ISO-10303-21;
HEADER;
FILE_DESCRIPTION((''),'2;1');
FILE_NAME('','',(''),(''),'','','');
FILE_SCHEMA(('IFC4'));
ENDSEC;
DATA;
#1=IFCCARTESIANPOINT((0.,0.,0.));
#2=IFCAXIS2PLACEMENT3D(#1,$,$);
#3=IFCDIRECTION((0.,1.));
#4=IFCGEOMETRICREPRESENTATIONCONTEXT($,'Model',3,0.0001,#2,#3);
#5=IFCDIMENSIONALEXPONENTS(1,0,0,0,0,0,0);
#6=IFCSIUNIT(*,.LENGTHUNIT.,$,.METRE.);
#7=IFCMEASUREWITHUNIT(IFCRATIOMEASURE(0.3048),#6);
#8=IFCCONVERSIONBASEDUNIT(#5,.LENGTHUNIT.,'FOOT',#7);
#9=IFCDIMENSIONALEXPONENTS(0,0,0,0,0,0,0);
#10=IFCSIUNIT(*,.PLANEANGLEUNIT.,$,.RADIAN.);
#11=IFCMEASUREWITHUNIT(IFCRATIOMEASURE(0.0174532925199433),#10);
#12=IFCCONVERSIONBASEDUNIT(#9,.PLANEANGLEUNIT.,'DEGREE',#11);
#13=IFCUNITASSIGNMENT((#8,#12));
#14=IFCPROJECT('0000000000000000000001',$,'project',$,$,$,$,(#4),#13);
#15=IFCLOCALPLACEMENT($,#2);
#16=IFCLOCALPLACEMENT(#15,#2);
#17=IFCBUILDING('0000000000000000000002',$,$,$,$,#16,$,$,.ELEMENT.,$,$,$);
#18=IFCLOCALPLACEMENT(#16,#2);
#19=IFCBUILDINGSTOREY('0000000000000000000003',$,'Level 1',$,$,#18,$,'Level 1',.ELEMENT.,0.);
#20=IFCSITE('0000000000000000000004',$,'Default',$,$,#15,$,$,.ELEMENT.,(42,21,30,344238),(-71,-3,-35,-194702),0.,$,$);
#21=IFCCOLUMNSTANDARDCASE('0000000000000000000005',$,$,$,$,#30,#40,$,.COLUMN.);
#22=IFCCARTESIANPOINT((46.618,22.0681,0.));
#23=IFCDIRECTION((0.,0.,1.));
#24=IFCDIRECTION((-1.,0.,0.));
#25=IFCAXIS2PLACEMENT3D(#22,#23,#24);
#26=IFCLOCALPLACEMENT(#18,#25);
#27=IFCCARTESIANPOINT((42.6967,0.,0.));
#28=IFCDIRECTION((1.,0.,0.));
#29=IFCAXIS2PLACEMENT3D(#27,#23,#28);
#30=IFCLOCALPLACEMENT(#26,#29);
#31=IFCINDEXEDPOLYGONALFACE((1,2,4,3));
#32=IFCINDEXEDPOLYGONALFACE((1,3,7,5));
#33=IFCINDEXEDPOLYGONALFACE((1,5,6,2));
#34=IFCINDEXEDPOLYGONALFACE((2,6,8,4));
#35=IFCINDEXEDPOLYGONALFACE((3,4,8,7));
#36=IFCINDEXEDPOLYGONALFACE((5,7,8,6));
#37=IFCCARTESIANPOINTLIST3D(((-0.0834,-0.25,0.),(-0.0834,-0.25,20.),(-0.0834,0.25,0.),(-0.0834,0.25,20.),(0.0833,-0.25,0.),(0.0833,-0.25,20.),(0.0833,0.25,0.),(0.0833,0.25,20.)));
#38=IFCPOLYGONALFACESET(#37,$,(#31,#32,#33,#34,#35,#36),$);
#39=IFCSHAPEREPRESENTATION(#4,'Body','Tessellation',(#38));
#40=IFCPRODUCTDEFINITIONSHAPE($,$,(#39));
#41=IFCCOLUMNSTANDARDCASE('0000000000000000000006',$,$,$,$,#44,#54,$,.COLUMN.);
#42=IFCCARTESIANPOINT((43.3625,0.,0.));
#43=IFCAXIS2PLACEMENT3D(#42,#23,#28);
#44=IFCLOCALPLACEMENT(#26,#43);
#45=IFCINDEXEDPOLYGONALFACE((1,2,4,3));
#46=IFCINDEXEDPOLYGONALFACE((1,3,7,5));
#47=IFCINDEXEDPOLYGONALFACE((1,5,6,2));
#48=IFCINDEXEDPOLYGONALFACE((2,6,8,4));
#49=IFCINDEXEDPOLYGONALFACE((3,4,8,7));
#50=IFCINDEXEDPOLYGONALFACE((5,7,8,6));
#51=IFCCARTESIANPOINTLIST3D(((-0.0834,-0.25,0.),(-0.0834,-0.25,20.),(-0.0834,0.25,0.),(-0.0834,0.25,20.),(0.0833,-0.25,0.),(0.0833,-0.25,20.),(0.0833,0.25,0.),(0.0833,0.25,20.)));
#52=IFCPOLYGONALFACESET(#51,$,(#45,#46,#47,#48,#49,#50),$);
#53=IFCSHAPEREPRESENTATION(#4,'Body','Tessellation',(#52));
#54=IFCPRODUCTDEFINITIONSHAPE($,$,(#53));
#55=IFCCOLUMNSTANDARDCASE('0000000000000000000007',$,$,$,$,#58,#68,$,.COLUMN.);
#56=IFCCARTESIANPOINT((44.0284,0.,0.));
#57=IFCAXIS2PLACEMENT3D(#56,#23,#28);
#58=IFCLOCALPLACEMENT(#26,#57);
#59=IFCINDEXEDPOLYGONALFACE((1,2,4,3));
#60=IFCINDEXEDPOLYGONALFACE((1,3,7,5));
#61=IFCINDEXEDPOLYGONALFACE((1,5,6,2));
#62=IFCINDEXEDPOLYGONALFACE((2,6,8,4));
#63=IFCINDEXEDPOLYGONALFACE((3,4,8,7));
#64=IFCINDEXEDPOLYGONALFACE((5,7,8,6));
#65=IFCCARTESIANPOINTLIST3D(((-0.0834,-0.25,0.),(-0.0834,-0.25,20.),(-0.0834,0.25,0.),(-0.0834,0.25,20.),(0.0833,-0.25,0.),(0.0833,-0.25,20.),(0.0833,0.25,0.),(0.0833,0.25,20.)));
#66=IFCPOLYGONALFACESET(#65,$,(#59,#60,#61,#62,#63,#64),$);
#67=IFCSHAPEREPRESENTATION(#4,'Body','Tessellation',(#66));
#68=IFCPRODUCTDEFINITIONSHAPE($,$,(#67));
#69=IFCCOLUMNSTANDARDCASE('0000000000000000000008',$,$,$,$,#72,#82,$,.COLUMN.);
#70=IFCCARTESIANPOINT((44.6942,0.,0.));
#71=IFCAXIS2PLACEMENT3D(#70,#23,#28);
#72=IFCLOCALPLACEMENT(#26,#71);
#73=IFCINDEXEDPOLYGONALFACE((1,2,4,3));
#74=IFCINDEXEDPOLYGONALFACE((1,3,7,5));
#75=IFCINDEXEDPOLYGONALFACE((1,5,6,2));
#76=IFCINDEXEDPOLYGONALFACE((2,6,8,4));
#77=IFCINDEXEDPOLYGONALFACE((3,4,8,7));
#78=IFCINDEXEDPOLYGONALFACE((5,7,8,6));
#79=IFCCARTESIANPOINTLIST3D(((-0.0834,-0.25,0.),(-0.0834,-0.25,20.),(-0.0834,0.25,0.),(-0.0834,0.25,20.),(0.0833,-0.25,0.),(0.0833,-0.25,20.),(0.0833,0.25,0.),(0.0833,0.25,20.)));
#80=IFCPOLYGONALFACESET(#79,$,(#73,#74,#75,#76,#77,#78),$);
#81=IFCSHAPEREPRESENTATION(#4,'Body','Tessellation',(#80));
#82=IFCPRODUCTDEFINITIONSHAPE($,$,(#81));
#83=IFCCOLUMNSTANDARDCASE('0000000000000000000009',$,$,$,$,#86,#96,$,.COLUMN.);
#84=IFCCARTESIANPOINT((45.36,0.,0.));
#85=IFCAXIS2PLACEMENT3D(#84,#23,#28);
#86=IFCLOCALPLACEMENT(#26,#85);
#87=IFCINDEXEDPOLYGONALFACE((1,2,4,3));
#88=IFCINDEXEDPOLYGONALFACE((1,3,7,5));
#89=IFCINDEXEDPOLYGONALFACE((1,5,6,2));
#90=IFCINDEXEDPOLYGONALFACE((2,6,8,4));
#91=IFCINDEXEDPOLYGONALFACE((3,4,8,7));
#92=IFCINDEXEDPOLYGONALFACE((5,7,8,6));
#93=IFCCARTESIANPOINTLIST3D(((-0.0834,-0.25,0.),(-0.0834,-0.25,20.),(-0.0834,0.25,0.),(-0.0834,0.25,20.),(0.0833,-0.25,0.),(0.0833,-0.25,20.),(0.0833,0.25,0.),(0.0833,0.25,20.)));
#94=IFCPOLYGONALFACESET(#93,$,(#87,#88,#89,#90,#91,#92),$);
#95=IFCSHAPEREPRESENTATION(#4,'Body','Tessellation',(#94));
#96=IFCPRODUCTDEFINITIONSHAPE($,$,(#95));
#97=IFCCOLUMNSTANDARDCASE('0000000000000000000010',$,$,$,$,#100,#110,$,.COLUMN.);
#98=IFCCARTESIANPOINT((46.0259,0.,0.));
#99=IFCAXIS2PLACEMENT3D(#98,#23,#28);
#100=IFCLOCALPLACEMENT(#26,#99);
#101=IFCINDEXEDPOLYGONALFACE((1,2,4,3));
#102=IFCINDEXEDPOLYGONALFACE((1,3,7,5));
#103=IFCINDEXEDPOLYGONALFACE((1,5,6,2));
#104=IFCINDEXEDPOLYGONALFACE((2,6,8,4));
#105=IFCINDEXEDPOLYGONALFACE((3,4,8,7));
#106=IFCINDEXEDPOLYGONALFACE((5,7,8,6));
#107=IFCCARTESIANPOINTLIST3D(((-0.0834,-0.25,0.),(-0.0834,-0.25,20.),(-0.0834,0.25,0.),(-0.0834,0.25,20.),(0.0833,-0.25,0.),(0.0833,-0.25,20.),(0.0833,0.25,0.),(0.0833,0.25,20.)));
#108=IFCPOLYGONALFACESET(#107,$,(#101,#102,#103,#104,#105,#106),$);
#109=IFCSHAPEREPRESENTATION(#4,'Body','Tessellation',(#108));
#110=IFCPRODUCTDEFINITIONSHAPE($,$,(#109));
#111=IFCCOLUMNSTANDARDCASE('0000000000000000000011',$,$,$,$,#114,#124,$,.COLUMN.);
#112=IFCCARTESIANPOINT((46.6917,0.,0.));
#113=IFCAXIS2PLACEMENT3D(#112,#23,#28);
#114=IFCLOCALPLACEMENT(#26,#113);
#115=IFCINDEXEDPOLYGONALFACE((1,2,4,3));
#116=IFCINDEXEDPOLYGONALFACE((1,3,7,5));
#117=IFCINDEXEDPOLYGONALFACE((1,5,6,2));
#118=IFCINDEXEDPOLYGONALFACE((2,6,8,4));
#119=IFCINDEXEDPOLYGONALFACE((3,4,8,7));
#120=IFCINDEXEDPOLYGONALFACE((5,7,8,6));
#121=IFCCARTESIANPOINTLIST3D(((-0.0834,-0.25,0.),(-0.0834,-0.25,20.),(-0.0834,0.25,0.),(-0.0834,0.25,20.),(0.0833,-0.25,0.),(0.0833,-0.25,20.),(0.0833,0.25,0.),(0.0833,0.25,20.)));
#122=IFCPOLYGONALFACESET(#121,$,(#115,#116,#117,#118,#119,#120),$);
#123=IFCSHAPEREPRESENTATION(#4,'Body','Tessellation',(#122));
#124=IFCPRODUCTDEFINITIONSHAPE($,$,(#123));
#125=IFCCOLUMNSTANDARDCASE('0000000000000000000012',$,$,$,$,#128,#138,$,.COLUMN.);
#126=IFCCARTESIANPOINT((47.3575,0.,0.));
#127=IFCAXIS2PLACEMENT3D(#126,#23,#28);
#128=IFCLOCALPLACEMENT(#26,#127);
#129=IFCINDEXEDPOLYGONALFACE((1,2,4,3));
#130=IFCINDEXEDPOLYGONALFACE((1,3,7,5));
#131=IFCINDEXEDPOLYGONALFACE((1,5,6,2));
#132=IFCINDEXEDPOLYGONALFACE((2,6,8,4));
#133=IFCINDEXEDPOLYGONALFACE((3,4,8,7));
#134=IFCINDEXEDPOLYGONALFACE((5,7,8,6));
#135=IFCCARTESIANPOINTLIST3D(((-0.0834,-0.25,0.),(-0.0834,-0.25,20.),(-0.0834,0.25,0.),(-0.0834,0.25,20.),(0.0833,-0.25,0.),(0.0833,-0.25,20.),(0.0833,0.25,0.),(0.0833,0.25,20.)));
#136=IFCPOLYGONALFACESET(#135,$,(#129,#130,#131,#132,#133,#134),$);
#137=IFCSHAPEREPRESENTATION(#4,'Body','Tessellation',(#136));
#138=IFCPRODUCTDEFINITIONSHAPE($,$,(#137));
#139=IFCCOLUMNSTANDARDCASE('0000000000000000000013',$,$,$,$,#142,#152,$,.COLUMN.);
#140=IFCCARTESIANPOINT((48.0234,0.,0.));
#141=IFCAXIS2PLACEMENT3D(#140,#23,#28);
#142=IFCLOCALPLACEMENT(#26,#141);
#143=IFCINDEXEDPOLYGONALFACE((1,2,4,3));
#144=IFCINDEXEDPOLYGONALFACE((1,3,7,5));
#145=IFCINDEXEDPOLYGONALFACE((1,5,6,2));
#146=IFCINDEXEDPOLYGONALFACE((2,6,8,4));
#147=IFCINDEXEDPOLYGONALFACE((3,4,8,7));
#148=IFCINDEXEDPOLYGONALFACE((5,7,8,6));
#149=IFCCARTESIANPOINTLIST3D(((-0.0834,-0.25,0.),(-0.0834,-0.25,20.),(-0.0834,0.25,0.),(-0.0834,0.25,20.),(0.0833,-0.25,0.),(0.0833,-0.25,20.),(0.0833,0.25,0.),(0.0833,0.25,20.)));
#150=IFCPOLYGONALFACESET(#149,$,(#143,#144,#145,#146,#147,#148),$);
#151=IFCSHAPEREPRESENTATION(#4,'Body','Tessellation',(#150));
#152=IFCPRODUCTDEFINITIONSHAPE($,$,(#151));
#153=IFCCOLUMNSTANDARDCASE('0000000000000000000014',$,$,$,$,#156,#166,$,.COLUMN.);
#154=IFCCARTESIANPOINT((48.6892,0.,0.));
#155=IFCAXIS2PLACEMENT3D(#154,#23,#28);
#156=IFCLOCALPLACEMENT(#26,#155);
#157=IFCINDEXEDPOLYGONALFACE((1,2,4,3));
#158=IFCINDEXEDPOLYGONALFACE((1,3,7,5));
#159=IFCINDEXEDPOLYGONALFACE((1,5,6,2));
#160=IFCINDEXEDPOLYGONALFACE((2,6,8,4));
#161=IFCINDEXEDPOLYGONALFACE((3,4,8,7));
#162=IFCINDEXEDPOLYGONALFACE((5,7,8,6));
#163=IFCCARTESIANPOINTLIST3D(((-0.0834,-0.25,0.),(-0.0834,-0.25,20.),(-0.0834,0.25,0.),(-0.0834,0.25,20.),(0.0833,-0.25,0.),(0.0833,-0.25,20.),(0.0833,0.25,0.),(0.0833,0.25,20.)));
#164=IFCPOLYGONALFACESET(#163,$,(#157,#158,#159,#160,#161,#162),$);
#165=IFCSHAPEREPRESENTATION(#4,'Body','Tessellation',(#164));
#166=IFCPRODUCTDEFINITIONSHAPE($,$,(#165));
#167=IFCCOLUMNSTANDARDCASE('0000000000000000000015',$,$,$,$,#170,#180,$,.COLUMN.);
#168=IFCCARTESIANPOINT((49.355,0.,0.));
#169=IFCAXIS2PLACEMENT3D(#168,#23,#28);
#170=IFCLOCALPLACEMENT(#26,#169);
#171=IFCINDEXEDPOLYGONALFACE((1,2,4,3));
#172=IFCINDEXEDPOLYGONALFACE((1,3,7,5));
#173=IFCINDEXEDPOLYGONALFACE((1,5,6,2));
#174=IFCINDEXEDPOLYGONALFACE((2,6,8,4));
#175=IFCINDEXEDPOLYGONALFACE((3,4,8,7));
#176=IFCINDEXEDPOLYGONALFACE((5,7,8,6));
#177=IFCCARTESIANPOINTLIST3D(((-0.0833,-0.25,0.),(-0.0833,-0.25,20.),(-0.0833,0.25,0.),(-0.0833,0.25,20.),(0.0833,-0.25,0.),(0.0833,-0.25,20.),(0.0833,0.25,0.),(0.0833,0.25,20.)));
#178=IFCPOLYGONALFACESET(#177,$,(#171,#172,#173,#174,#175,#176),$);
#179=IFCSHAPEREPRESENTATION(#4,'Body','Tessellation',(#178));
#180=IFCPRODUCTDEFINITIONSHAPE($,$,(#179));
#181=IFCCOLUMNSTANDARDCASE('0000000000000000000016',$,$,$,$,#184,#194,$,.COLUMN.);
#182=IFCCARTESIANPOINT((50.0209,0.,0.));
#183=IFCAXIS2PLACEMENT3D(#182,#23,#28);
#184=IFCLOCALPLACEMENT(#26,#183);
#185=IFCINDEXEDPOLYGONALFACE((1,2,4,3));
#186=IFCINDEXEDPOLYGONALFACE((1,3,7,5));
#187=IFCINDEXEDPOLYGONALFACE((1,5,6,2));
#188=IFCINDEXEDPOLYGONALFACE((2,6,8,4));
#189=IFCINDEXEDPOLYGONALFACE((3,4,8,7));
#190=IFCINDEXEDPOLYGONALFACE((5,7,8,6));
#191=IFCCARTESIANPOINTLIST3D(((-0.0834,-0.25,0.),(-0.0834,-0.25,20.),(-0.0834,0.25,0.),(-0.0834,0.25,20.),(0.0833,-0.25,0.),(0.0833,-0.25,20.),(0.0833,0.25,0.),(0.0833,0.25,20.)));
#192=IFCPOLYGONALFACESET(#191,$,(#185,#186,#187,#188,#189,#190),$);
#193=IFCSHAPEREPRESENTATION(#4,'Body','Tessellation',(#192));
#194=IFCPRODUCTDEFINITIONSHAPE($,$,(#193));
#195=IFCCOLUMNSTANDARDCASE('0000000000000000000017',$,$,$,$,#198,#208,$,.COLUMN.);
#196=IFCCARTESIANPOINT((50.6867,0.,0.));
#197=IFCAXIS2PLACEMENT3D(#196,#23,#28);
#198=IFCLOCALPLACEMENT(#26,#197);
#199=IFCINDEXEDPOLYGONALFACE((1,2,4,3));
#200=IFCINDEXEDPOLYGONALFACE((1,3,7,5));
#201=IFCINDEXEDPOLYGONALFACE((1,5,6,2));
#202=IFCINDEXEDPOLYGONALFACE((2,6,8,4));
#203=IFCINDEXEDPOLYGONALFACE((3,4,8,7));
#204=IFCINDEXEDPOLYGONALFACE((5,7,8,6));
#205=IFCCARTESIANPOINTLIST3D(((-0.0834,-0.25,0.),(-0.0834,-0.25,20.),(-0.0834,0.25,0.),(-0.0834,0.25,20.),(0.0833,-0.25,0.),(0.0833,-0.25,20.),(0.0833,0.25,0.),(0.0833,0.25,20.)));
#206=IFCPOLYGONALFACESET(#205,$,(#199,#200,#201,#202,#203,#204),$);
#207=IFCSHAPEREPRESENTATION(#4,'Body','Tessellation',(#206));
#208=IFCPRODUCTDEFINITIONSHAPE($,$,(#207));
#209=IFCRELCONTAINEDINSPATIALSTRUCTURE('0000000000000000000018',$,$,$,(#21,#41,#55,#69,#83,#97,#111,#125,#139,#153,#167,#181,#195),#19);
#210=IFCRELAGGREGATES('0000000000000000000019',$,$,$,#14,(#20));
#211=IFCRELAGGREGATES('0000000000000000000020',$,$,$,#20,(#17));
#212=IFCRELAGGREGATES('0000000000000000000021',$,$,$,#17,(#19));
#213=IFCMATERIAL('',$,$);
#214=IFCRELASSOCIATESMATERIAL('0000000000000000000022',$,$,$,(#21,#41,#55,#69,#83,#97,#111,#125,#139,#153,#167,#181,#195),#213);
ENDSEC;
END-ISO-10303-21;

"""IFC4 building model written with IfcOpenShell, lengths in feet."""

from ifc_helpers import new_model, entity, si_unit, converted_unit, direction, frame, origin, place, context, project, spatial, rectangle, extrude, material, element, save


model = new_model("IFC4")

# Units and contexts
model_context = context("Model", 3, precision=0.0001, world=origin(), true_north=direction((0.0, 1.0)))
ifc_project = project(units=[converted_unit("LENGTHUNIT", "FOOT", entity("IfcRatioMeasure", 0.3048), si_unit("LENGTHUNIT", "METRE"), dimensions=[1, 0, 0, 0, 0, 0, 0]), converted_unit("PLANEANGLEUNIT", "DEGREE", entity("IfcRatioMeasure", 0.0174532925199433), si_unit("PLANEANGLEUNIT", "RADIAN"), dimensions=[0, 0, 0, 0, 0, 0, 0])], contexts=[model_context])

# Site, building, storey
site_placement = place(None, origin())
site = spatial("IfcSite", under=ifc_project, at=site_placement, Name="Default", CompositionType="ELEMENT", RefLatitude=(42, 21, 30, 344238), RefLongitude=(-71, -3, -35, -194702), RefElevation=0.0)
building_placement = place(site_placement, origin())
building = spatial("IfcBuilding", under=site, at=building_placement, CompositionType="ELEMENT")
storey_placement = place(building_placement, origin())
storey = spatial("IfcBuildingStorey", under=building, at=storey_placement, Name="Level 1", LongName="Level 1", CompositionType="ELEMENT", Elevation=0.0)

# Columns
ifc_material = material(Name="")
placement = place(storey_placement, frame((46.618, 22.0681, 0.0), z_axis=(0.0, 0.0, 1.0), x_axis=(-1.0, 0.0, 0.0)))
for number, where, z_axis, x_axis in (
    (1, (42.6967, 0.0, 0.0), (0.0, 0.0, 1.0), (1.0, 0.0, 0.0)),
    (2, (43.3625, 0.0, 0.0), (0.0, 0.0, 1.0), (1.0, 0.0, 0.0)),
    (3, (44.0284, 0.0, 0.0), (0.0, 0.0, 1.0), (1.0, 0.0, 0.0)),
    (4, (44.6942, 0.0, 0.0), (0.0, 0.0, 1.0), (1.0, 0.0, 0.0)),
    (5, (45.36, 0.0, 0.0), (0.0, 0.0, 1.0), (1.0, 0.0, 0.0)),
    (6, (46.0259, 0.0, 0.0), (0.0, 0.0, 1.0), (1.0, 0.0, 0.0)),
    (7, (46.6917, 0.0, 0.0), (0.0, 0.0, 1.0), (1.0, 0.0, 0.0)),
    (8, (47.3575, 0.0, 0.0), (0.0, 0.0, 1.0), (1.0, 0.0, 0.0)),
    (9, (48.0234, 0.0, 0.0), (0.0, 0.0, 1.0), (1.0, 0.0, 0.0)),
    (10, (48.6892, 0.0, 0.0), (0.0, 0.0, 1.0), (1.0, 0.0, 0.0)),
    (11, (49.355, 0.0, 0.0), (0.0, 0.0, 1.0), (1.0, 0.0, 0.0)),
    (12, (50.0209, 0.0, 0.0), (0.0, 0.0, 1.0), (1.0, 0.0, 0.0)),
    (13, (50.6867, 0.0, 0.0), (0.0, 0.0, 1.0), (1.0, 0.0, 0.0)),
):
    element("IfcColumnStandardCase", number, at=place(placement, frame(where, z_axis=z_axis, x_axis=x_axis)), inside=storey, material=ifc_material, PredefinedType="COLUMN", context=model_context, shape_type="SweptSolid", body=[
        extrude(rectangle(XDim=0.1667, YDim=0.5), origin(), (0.0, 0.0, 1.0), 20.0),
    ])

save(model, "model.ifc")
